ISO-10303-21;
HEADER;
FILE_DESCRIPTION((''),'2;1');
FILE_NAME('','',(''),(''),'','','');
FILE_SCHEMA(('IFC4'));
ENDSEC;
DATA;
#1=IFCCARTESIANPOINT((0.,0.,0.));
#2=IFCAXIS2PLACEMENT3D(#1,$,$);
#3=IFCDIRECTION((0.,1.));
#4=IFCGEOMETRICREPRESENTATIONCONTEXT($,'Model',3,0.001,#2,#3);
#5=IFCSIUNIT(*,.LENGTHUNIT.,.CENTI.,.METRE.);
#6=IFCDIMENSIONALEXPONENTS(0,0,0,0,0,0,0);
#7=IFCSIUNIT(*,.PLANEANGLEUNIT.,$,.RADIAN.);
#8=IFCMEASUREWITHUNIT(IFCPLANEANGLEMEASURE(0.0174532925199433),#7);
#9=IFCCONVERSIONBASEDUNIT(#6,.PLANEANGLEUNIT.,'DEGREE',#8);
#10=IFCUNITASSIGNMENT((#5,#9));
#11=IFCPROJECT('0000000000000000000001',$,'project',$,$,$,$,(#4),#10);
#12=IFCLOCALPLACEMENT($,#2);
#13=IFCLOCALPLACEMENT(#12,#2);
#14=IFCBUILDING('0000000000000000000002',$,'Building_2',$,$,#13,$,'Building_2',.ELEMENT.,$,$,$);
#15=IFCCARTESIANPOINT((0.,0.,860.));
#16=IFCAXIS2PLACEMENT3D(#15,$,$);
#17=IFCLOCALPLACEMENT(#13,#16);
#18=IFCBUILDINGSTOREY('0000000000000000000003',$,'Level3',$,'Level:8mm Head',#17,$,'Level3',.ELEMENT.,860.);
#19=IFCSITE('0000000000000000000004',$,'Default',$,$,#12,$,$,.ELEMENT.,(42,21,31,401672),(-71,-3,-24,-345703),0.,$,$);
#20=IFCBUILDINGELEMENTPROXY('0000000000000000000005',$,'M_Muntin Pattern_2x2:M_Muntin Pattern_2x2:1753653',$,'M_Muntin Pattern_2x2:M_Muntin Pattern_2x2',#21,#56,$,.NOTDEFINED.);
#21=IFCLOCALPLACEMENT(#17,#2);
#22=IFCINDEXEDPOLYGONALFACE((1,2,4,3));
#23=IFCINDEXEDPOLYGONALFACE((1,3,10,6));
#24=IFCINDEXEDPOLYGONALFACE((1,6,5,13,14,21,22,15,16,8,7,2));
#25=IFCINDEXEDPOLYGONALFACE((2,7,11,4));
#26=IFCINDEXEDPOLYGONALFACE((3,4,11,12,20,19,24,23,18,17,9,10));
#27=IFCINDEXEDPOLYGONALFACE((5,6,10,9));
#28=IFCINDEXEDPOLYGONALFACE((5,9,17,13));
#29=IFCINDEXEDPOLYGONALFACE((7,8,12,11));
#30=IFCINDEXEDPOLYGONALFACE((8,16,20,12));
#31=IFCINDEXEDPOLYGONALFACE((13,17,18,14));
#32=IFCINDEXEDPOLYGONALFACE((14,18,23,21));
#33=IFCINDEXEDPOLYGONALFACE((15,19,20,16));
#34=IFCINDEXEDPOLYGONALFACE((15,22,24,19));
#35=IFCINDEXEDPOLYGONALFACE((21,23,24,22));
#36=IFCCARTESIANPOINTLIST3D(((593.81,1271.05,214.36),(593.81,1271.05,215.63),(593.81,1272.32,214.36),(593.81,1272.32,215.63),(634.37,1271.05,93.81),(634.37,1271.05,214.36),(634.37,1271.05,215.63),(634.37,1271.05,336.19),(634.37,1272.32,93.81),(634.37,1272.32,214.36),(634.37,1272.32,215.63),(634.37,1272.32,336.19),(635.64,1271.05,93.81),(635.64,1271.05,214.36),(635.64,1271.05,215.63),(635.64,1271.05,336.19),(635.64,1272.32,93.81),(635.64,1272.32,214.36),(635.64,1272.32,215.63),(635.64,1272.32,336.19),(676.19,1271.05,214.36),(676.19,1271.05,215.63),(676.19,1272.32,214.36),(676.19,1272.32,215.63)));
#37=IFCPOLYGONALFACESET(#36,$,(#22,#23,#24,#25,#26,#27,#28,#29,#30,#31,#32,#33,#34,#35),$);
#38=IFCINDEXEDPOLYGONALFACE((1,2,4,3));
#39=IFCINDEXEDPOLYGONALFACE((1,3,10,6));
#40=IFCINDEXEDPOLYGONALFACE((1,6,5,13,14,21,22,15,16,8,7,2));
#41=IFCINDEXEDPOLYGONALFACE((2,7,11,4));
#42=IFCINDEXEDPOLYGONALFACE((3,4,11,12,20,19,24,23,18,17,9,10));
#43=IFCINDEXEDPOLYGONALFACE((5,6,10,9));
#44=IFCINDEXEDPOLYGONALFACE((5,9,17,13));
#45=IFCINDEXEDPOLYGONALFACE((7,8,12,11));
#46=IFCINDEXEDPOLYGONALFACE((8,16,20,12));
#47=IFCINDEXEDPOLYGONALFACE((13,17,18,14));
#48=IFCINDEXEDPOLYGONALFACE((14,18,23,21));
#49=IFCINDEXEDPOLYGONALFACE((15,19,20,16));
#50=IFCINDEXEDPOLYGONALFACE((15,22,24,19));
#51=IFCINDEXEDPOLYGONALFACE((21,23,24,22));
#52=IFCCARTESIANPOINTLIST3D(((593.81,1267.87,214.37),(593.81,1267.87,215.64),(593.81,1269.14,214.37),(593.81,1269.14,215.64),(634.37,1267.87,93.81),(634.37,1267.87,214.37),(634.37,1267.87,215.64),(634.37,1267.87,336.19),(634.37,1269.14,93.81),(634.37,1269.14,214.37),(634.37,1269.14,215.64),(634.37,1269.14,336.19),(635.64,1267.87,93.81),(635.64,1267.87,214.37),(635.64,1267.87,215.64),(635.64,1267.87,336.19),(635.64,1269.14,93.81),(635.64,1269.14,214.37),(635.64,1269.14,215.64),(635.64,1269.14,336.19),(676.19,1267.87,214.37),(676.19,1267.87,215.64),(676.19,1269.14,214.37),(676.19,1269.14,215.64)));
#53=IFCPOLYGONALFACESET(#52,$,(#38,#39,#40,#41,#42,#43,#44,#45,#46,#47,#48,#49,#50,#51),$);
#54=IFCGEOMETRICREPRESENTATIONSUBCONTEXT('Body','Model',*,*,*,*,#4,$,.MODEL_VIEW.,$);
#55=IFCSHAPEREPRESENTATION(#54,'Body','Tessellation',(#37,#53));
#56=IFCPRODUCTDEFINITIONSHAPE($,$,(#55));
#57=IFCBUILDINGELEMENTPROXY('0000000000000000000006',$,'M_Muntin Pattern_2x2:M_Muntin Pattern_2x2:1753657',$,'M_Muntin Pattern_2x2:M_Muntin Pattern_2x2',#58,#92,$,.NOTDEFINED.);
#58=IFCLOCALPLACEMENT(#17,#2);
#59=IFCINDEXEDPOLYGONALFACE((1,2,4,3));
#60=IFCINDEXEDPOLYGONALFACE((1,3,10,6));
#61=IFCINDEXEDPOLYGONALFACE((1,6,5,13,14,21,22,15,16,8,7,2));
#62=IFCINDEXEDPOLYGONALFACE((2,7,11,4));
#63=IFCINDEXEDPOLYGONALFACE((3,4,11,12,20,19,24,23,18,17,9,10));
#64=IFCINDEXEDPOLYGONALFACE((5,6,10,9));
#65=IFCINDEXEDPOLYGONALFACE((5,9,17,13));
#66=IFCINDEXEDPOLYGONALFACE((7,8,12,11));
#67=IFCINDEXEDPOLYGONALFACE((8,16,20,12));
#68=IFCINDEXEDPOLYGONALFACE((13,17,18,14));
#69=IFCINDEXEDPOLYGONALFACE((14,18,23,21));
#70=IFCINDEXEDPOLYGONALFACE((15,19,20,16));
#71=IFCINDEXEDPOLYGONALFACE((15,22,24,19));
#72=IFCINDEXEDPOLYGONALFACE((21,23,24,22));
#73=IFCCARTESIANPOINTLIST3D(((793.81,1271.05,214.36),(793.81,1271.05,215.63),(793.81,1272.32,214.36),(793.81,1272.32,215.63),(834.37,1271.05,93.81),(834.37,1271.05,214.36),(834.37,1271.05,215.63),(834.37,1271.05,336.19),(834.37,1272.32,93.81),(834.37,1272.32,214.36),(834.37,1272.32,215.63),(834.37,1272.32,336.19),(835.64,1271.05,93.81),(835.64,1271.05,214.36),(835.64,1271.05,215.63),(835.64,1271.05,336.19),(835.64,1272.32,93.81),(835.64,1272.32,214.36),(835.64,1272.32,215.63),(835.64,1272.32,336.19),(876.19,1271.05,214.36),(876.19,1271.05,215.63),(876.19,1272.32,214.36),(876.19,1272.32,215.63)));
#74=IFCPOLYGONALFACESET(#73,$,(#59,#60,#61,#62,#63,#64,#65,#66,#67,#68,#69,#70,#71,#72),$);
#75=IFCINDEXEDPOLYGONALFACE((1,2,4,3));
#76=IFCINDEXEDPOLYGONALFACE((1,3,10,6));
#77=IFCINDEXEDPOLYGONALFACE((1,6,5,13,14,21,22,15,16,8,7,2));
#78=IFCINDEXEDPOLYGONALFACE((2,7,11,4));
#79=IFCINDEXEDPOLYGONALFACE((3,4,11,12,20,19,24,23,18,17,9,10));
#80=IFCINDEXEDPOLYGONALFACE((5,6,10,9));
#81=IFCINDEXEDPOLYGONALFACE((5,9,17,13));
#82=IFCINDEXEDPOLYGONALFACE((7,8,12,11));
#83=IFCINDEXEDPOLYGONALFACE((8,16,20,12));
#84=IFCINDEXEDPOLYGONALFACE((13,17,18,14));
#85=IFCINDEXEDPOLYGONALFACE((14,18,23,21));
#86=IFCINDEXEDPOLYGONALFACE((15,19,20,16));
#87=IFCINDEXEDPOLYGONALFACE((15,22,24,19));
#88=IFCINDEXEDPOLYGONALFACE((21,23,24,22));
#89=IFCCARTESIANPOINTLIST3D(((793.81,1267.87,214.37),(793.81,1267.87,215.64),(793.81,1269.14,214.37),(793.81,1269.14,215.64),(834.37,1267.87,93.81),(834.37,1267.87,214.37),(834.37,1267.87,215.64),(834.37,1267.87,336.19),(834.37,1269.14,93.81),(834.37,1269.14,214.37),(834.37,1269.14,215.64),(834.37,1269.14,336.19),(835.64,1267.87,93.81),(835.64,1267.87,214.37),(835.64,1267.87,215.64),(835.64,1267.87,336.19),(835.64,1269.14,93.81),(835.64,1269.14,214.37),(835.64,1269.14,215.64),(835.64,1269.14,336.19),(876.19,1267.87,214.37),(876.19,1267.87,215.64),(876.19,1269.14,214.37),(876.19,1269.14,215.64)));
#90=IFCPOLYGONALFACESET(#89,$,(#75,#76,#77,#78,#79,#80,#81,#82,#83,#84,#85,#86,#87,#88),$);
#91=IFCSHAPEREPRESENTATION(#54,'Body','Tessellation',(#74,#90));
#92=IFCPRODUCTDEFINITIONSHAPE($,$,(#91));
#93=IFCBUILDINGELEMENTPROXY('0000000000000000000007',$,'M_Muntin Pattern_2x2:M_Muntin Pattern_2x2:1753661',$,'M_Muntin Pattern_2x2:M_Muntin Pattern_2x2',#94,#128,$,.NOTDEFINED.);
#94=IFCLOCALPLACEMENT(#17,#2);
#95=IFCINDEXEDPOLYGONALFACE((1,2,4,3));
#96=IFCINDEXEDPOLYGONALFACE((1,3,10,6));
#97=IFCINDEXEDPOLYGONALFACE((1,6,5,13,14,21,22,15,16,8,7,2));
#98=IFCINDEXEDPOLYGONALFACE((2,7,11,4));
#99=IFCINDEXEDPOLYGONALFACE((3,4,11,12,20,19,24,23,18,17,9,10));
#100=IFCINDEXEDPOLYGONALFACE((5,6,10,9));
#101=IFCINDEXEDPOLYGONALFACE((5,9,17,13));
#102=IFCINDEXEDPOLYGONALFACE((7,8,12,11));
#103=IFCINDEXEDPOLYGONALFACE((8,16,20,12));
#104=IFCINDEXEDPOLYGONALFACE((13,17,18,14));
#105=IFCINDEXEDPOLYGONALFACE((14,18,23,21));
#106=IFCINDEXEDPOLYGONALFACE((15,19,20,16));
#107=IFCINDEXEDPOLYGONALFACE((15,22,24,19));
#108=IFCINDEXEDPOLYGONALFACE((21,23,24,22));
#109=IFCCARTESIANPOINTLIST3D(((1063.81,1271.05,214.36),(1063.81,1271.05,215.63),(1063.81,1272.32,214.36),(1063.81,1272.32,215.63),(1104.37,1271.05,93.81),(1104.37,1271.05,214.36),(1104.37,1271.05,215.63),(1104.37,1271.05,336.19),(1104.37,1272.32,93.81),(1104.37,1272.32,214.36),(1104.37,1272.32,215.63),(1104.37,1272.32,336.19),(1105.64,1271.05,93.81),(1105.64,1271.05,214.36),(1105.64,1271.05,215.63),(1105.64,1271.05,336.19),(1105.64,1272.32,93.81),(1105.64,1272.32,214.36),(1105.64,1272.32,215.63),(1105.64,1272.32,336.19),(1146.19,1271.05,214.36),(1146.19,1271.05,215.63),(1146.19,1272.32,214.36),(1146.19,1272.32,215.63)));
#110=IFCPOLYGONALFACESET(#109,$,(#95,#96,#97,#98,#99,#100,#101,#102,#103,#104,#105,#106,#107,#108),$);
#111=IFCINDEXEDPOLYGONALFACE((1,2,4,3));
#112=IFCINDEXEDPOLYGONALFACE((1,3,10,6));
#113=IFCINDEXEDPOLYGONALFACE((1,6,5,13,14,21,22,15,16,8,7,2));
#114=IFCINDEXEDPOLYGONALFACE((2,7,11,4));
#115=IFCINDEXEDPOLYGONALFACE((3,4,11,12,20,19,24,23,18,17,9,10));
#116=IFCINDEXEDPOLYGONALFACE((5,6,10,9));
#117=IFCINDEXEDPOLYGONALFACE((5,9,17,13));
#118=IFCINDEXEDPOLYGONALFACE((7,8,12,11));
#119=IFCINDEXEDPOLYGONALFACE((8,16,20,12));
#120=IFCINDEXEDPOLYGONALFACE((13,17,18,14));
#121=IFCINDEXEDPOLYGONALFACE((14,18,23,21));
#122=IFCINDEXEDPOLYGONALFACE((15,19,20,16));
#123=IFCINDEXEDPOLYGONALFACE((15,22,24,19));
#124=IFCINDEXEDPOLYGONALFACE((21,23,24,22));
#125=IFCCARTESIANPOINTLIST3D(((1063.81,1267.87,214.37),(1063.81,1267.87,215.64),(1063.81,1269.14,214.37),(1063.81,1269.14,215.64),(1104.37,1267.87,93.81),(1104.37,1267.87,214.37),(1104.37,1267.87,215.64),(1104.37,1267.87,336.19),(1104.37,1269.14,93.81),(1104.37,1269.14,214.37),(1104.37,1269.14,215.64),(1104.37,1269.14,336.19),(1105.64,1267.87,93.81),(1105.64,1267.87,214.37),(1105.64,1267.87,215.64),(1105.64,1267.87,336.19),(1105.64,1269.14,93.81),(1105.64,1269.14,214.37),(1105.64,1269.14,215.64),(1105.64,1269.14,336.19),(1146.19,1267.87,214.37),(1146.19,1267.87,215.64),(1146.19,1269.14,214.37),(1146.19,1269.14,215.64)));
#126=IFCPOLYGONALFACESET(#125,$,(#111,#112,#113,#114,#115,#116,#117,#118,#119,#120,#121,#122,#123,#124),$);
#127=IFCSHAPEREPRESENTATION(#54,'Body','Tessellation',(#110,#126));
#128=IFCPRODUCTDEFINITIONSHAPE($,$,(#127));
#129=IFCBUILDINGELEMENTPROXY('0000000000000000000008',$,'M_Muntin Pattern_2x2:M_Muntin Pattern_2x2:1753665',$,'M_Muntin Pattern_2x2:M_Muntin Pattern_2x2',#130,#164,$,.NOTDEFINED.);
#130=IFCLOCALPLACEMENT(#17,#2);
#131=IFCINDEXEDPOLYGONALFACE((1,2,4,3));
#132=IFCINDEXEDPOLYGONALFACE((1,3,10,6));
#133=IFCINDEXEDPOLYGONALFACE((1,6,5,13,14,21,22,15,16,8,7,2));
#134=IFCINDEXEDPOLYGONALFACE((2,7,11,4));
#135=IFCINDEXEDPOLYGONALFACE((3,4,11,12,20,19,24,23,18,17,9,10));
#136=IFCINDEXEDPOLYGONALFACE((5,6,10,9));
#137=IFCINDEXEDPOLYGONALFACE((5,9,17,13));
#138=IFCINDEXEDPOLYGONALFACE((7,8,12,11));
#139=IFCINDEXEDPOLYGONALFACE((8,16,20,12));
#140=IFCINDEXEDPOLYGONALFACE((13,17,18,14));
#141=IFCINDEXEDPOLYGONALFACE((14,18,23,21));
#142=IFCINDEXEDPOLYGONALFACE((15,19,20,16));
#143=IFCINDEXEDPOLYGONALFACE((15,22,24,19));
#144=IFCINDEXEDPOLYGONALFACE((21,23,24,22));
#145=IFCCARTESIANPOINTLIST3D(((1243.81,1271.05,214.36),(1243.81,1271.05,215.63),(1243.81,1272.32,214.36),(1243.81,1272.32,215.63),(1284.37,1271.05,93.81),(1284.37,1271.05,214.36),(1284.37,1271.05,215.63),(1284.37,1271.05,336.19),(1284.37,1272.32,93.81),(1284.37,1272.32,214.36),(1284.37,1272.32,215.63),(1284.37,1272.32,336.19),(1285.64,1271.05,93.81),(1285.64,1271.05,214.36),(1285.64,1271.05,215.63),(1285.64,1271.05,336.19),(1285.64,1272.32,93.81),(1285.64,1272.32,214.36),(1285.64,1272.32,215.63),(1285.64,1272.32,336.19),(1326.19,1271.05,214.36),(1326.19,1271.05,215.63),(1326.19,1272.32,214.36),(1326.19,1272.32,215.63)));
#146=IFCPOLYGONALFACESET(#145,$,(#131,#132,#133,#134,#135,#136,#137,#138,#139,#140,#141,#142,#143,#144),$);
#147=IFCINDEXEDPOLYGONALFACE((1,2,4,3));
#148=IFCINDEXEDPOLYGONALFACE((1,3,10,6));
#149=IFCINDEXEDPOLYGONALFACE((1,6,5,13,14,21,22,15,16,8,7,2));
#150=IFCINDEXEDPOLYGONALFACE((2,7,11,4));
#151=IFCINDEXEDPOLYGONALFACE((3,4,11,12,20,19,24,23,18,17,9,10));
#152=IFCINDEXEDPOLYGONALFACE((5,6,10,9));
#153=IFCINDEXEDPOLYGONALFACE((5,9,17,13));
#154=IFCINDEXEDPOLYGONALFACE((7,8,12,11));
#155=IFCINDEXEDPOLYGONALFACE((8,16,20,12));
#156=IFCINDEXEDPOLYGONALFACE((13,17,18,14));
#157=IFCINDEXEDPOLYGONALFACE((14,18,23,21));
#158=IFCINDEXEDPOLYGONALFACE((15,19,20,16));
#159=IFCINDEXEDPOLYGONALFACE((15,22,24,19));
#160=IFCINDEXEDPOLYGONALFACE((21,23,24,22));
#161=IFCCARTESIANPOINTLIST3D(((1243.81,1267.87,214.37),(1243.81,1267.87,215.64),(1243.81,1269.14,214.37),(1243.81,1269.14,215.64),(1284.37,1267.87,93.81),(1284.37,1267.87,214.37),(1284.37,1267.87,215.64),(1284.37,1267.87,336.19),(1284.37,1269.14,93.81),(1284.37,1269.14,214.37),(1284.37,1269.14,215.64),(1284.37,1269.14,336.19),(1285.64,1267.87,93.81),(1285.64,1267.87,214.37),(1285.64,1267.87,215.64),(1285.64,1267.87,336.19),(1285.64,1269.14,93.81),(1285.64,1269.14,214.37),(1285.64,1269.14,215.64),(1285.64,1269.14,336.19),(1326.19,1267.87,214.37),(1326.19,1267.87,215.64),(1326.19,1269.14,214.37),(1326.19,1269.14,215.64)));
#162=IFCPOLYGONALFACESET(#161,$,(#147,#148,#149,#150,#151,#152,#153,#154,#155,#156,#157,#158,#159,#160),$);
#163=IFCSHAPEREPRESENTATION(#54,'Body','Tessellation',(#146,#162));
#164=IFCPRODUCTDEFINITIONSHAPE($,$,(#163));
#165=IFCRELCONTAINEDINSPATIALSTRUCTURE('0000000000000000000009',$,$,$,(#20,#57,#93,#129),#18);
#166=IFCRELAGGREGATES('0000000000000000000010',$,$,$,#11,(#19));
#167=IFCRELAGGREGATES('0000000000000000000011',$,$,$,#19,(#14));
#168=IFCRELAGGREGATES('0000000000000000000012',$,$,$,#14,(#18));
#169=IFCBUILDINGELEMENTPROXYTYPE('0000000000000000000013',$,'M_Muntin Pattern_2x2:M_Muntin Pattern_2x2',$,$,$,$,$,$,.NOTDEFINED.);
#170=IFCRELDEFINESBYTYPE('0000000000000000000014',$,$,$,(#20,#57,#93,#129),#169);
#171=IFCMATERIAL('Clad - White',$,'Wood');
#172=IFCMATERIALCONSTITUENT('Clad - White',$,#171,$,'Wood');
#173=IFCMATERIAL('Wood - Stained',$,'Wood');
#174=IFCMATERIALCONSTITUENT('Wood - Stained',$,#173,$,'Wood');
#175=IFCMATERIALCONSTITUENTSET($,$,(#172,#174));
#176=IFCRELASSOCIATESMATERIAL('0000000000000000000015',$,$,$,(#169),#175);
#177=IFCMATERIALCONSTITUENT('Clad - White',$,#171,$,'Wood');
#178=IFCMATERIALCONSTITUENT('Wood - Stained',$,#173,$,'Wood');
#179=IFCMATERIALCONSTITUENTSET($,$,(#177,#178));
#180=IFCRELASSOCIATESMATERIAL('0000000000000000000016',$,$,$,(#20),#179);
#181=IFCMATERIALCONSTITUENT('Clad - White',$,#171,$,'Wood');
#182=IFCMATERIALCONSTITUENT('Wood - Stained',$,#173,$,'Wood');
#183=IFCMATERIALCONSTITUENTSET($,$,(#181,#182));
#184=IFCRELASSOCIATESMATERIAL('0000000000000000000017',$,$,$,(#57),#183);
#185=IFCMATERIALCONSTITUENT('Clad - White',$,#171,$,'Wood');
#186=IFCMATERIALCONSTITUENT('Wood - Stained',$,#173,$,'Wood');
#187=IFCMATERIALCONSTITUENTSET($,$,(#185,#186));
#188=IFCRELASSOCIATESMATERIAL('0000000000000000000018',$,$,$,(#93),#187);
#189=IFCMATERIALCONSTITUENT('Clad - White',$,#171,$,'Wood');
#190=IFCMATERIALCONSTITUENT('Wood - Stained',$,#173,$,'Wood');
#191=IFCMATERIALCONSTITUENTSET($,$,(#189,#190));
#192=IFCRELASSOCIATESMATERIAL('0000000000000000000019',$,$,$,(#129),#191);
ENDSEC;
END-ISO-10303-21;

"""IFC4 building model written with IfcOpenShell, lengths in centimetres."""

from ifc_helpers import new_model, entity, si_unit, converted_unit, direction, frame, origin, place, context, subcontext, project, spatial, indexed_curve, outline, extrude, source, transform, mapped, material, constituent, constituent_set, type_object, type_shapes, element, save


model = new_model("IFC4")

# Units and contexts
model_context = context("Model", 3, precision=0.001, world=origin(), true_north=direction((0.0, 1.0)))
body_context = subcontext(model_context, "Body", "Model", "MODEL_VIEW")
ifc_project = project(units=[si_unit("LENGTHUNIT", "METRE", prefix="CENTI"), converted_unit("PLANEANGLEUNIT", "DEGREE", entity("IfcPlaneAngleMeasure", 0.0174532925199433), si_unit("PLANEANGLEUNIT", "RADIAN"), dimensions=[0, 0, 0, 0, 0, 0, 0])], contexts=[model_context])

# Site, building, storey
site_placement = place(None, origin())
site = spatial("IfcSite", under=ifc_project, at=site_placement, Name="Default", CompositionType="ELEMENT", RefLatitude=(42, 21, 31, 401672), RefLongitude=(-71, -3, -24, -345703), RefElevation=0.0)
building_placement = place(site_placement, origin())
building = spatial("IfcBuilding", under=site, at=building_placement, Name="Building_2", LongName="Building_2", CompositionType="ELEMENT")
storey_placement = place(building_placement, frame((0.0, 0.0, 860.0)))
storey = spatial("IfcBuildingStorey", under=building, at=storey_placement, Name="Level3", ObjectType="Level:8mm Head", LongName="Level3", CompositionType="ELEMENT", Elevation=860.0)

# Building element proxies
ifc_material_1 = material(Name="Clad - White", Category="Wood")
ifc_constituent_1 = constituent(ifc_material_1, Name="Clad - White", Category="Wood")
ifc_material_2 = material(Name="Wood - Stained", Category="Wood")
ifc_constituent_2 = constituent(ifc_material_2, Name="Wood - Stained", Category="Wood")
ifc_constituent_set_1 = constituent_set(constituents=[ifc_constituent_1, ifc_constituent_2])
ifc_constituent_3 = constituent(ifc_material_1, Name="Clad - White", Category="Wood")
ifc_constituent_4 = constituent(ifc_material_2, Name="Wood - Stained", Category="Wood")
ifc_constituent_set_2 = constituent_set(constituents=[ifc_constituent_3, ifc_constituent_4])
building_element_proxy_type_1 = type_object("IfcBuildingElementProxyType", Name="M_Muntin Pattern_2x2:M_Muntin Pattern_2x2", PredefinedType="NOTDEFINED", material=ifc_constituent_set_2)
shared_shape_1 = source(origin(), body_context, "Body", "SweptSolid", [
    extrude(outline(indexed_curve([(0.64, -0.64), (121.19, -0.64), (121.19, 0.63), (0.64, 0.63), (0.64, 41.19), (-0.63, 41.19), (-0.63, 0.63), (-121.19, 0.63), (-121.19, -0.64), (-0.63, -0.64), (-0.63, -41.19), (0.64, -41.19), (0.64, -0.64)], self_intersect=False)), frame((0.0, -2.22, 121.19), z_axis=(0.0, 1.0, 0.0), x_axis=(0.0, 0.0, 1.0)), (0.0, 0.0, 1.0), 1.27),
    extrude(outline(indexed_curve([(0.64, -0.64), (121.19, -0.64), (121.19, 0.63), (0.64, 0.63), (0.64, 41.19), (-0.63, 41.19), (-0.63, 0.63), (-121.19, 0.63), (-121.19, -0.64), (-0.63, -0.64), (-0.63, -41.19), (0.64, -41.19), (0.64, -0.64)], self_intersect=False)), frame((0.0, 0.95, 121.19), z_axis=(0.0, 1.0, 0.0), x_axis=(0.0, 0.0, 1.0)), (0.0, 0.0, 1.0), 1.27),
])
type_shapes(building_element_proxy_type_1, [shared_shape_1])
proxy_1_placement = place(storey_placement, frame((635.0, 1270.1, 93.81), z_axis=(0.0, 0.0, 1.0), x_axis=(-1.0, 0.0, 0.0)))
element("IfcBuildingElementProxy", 1, at=proxy_1_placement, inside=storey, type_object=building_element_proxy_type_1, material=ifc_constituent_set_1, Name="M_Muntin Pattern_2x2:M_Muntin Pattern_2x2:1753653", ObjectType="M_Muntin Pattern_2x2:M_Muntin Pattern_2x2", PredefinedType="NOTDEFINED", context=body_context, shape_type="MappedRepresentation", body=[
    mapped(shared_shape_1, transform((0.0, 0.0, 0.0), scale=1.0)),
])
ifc_constituent_5 = constituent(ifc_material_1, Name="Clad - White", Category="Wood")
ifc_constituent_6 = constituent(ifc_material_2, Name="Wood - Stained", Category="Wood")
ifc_constituent_set_3 = constituent_set(constituents=[ifc_constituent_5, ifc_constituent_6])
proxy_2_placement = place(storey_placement, frame((835.0, 1270.1, 93.81), z_axis=(0.0, 0.0, 1.0), x_axis=(-1.0, 0.0, 0.0)))
element("IfcBuildingElementProxy", 2, at=proxy_2_placement, inside=storey, type_object=building_element_proxy_type_1, material=ifc_constituent_set_3, Name="M_Muntin Pattern_2x2:M_Muntin Pattern_2x2:1753657", ObjectType="M_Muntin Pattern_2x2:M_Muntin Pattern_2x2", PredefinedType="NOTDEFINED", context=body_context, shape_type="MappedRepresentation", body=[
    mapped(shared_shape_1, transform((0.0, 0.0, 0.0), scale=1.0)),
])
ifc_constituent_7 = constituent(ifc_material_1, Name="Clad - White", Category="Wood")
ifc_constituent_8 = constituent(ifc_material_2, Name="Wood - Stained", Category="Wood")
ifc_constituent_set_4 = constituent_set(constituents=[ifc_constituent_7, ifc_constituent_8])
proxy_3_placement = place(storey_placement, frame((1105.0, 1270.1, 93.81), z_axis=(0.0, 0.0, 1.0), x_axis=(-1.0, 0.0, 0.0)))
element("IfcBuildingElementProxy", 3, at=proxy_3_placement, inside=storey, type_object=building_element_proxy_type_1, material=ifc_constituent_set_4, Name="M_Muntin Pattern_2x2:M_Muntin Pattern_2x2:1753661", ObjectType="M_Muntin Pattern_2x2:M_Muntin Pattern_2x2", PredefinedType="NOTDEFINED", context=body_context, shape_type="MappedRepresentation", body=[
    mapped(shared_shape_1, transform((0.0, 0.0, 0.0), scale=1.0)),
])
ifc_constituent_9 = constituent(ifc_material_1, Name="Clad - White", Category="Wood")
ifc_constituent_10 = constituent(ifc_material_2, Name="Wood - Stained", Category="Wood")
ifc_constituent_set_5 = constituent_set(constituents=[ifc_constituent_9, ifc_constituent_10])
proxy_4_placement = place(storey_placement, frame((1285.0, 1270.1, 93.81), z_axis=(0.0, 0.0, 1.0), x_axis=(-1.0, 0.0, 0.0)))
element("IfcBuildingElementProxy", 4, at=proxy_4_placement, inside=storey, type_object=building_element_proxy_type_1, material=ifc_constituent_set_5, Name="M_Muntin Pattern_2x2:M_Muntin Pattern_2x2:1753665", ObjectType="M_Muntin Pattern_2x2:M_Muntin Pattern_2x2", PredefinedType="NOTDEFINED", context=body_context, shape_type="MappedRepresentation", body=[
    mapped(shared_shape_1, transform((0.0, 0.0, 0.0), scale=1.0)),
])

save(model, "model.ifc")
